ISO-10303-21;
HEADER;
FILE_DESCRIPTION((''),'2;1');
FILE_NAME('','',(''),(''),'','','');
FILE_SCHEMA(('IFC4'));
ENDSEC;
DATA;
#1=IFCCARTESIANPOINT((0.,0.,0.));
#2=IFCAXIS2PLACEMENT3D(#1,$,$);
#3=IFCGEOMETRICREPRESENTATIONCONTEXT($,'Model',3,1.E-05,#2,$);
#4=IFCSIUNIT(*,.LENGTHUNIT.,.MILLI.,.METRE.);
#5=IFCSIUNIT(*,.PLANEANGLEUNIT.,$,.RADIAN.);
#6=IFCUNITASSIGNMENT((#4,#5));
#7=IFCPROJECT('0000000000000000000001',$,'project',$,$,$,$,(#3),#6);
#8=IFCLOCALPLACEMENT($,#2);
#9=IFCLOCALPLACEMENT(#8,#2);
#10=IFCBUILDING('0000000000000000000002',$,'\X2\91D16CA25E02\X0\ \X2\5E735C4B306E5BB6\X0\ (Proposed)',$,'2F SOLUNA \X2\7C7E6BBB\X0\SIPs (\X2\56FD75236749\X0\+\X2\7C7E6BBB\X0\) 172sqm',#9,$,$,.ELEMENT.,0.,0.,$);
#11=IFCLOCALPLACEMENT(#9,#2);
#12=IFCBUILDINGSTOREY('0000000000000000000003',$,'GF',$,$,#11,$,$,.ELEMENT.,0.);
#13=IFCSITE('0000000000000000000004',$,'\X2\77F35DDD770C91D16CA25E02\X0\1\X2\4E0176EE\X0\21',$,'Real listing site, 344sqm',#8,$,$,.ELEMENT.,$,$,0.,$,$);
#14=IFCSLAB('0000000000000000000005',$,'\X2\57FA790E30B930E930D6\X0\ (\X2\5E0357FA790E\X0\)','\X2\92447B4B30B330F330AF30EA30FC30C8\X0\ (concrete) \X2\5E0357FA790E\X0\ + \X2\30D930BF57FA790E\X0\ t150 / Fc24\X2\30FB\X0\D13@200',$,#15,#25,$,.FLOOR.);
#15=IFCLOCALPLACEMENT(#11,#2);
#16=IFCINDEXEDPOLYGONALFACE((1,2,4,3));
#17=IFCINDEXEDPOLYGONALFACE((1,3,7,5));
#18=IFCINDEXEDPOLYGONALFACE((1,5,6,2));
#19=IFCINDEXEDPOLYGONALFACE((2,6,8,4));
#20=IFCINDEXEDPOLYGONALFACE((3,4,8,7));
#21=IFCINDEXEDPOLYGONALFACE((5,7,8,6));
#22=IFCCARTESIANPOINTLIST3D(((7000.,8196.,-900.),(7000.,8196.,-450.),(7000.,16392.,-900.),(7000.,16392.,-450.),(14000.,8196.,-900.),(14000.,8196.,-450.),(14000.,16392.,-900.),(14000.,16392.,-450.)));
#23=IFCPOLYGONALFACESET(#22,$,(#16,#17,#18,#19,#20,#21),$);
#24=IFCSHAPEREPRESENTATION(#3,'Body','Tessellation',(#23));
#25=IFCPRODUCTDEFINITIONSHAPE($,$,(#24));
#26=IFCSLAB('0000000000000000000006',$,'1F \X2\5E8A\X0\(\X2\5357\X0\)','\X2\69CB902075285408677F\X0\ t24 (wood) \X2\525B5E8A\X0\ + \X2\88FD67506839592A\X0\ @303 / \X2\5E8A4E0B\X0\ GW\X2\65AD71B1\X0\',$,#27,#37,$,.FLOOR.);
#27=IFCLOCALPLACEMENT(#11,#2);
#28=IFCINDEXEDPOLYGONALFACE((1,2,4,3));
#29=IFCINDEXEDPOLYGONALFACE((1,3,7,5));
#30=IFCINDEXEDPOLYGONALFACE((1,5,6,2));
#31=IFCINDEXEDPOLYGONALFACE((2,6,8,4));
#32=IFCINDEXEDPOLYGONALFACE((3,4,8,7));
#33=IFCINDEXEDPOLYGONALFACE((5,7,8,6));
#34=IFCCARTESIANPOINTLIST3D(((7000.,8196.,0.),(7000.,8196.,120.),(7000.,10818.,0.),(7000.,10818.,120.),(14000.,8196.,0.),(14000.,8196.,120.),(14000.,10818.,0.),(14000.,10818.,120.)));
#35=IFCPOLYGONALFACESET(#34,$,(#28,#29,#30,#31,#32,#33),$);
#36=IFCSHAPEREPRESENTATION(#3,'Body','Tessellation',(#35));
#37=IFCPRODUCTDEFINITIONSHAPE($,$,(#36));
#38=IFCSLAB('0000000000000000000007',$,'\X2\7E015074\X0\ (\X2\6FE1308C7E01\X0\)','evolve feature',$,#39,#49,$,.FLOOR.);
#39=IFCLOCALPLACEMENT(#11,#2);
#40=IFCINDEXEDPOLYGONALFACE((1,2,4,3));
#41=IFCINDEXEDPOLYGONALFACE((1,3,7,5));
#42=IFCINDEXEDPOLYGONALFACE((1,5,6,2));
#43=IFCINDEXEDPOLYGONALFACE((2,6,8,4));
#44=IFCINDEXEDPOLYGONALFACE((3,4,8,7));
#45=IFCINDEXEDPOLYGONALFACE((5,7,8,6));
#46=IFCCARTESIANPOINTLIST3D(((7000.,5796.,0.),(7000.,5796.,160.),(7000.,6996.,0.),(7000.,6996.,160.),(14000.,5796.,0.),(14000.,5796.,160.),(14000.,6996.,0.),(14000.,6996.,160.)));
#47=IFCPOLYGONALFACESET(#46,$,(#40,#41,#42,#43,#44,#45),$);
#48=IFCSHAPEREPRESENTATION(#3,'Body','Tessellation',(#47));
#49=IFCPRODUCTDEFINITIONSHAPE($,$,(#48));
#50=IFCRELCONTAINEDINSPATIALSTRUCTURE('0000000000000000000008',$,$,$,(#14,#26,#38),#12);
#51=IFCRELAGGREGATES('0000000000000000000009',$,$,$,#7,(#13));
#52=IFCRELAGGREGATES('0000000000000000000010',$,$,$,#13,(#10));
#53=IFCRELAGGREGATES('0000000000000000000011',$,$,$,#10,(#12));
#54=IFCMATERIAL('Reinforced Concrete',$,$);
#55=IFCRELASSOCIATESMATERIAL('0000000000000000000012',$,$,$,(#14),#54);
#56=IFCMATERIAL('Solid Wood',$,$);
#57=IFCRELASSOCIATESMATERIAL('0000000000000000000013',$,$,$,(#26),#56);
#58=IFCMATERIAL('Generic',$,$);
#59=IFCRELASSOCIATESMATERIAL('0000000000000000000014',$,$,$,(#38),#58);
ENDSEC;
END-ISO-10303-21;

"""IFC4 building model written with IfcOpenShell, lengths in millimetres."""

from ifc_helpers import new_model, si_unit, frame, frame_2d, origin, place, context, project, spatial, rectangle, extrude, material, element, save


model = new_model("IFC4")

# Units and contexts
model_context = context("Model", 3, precision=1e-05, world=origin())
ifc_project = project(units=[si_unit("LENGTHUNIT", "METRE", prefix="MILLI"), si_unit("PLANEANGLEUNIT", "RADIAN")], contexts=[model_context])

# Site, building, storey
site_placement = place(None, origin())
site = spatial("IfcSite", under=ifc_project, at=site_placement, Name="石川県金沢市1丁目21", ObjectType="Real listing site, 344sqm", CompositionType="ELEMENT", RefElevation=0.0)
building_placement = place(site_placement, origin())
building = spatial("IfcBuilding", under=site, at=building_placement, Name="金沢市 平屋の家 (Proposed)", ObjectType="2F SOLUNA 籾殻SIPs (国産杉+籾殻) 172sqm", CompositionType="ELEMENT", ElevationOfRefHeight=0.0, ElevationOfTerrain=0.0)
storey_placement = place(building_placement, origin())
storey = spatial("IfcBuildingStorey", under=building, at=storey_placement, Name="GF", CompositionType="ELEMENT", Elevation=0.0)

# Slabs
ifc_material_1 = material(Name="Reinforced Concrete")
slab_1_placement = place(storey_placement, frame((3500.0, 4098.0, -450.0)))
element("IfcSlab", 1, at=slab_1_placement, inside=storey, material=ifc_material_1, Name="基礎スラブ (布基礎)", Description="鉄筋コンクリート (concrete) 布基礎 + ベタ基礎 t150 / Fc24・D13@200", PredefinedType="FLOOR", context=model_context, shape_type="SweptSolid", body=[
    extrude(rectangle(XDim=7000.0, YDim=8196.0, at=frame_2d((3500.0, 4098.0))), frame((3500.0, 4098.0, -450.0)), (0.0, 0.0, 1.0), 450.0),
])
ifc_material_2 = material(Name="Solid Wood")
slab_2_placement = place(storey_placement, frame((3500.0, 4098.0, 0.0)))
element("IfcSlab", 2, at=slab_2_placement, inside=storey, material=ifc_material_2, Name="1F 床(南)", Description="構造用合板 t24 (wood) 剛床 + 製材根太 @303 / 床下 GW断熱", PredefinedType="FLOOR", context=model_context, shape_type="SweptSolid", body=[
    extrude(rectangle(XDim=7000.0, YDim=2622.0, at=frame_2d((3500.0, 1311.0))), frame((3500.0, 4098.0, 0.0)), (0.0, 0.0, 1.0), 120.0),
])
ifc_material_3 = material(Name="Generic")
slab_3_placement = place(storey_placement, frame((3500.0, 2898.0, 0.0)))
element("IfcSlab", 3, at=slab_3_placement, inside=storey, material=ifc_material_3, Name="縁側 (濡れ縁)", Description="evolve feature", PredefinedType="FLOOR", context=model_context, shape_type="SweptSolid", body=[
    extrude(rectangle(XDim=7000.0, YDim=1200.0, at=frame_2d((3500.0, 600.0))), frame((3500.0, 2898.0, 0.0)), (0.0, 0.0, 1.0), 160.0),
])

save(model, "model.ifc")
